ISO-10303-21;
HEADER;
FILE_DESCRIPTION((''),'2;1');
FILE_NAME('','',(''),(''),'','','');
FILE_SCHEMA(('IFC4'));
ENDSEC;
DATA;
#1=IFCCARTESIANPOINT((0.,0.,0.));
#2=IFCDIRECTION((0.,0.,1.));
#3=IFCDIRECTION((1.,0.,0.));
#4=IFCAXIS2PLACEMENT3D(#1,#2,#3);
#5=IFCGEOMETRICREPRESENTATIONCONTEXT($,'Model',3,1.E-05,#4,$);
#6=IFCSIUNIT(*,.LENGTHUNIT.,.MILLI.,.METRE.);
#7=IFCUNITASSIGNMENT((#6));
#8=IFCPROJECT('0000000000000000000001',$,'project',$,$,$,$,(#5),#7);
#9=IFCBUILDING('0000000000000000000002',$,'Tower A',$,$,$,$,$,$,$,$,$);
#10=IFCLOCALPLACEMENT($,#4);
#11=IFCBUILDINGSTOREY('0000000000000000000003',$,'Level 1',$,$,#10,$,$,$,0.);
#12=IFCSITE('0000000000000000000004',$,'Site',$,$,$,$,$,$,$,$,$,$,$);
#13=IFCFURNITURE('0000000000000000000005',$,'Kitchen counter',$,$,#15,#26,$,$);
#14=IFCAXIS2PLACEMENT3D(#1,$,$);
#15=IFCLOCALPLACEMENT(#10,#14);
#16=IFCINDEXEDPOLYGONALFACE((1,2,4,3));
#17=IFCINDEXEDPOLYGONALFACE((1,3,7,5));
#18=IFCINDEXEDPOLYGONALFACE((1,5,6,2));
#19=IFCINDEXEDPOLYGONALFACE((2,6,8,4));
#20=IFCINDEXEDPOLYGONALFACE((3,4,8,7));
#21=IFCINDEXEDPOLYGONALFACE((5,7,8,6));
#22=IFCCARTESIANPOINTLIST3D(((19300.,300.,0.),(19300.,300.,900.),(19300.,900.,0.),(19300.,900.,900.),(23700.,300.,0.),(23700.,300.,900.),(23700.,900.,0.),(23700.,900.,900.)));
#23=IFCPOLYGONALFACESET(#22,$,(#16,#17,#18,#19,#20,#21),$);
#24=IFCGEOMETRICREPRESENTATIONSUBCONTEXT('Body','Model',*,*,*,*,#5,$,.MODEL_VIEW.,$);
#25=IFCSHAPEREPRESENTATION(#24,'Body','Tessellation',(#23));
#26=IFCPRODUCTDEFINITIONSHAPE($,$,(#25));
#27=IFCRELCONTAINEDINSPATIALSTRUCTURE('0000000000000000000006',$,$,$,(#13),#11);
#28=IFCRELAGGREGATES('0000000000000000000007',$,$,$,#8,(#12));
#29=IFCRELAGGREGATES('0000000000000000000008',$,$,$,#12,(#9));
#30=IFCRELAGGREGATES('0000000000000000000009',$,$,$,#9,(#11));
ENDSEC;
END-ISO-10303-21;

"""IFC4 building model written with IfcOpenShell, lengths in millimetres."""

from ifc_helpers import new_model, si_unit, frame, origin_with_axes, place, context, subcontext, project, spatial, indexed_curve, outline, extrude, element, save


model = new_model("IFC4")

# Units and contexts
model_context = context("Model", 3, precision=1e-05, world=origin_with_axes())
body_context = subcontext(model_context, "Body", "Model", "MODEL_VIEW")
ifc_project = project(units=[si_unit("LENGTHUNIT", "METRE", prefix="MILLI")], contexts=[model_context])

# Site, building, storey
site = spatial("IfcSite", under=ifc_project, Name="Site")
building = spatial("IfcBuilding", under=site, Name="Tower A")
storey_placement = place(None, origin_with_axes())
storey = spatial("IfcBuildingStorey", under=building, at=storey_placement, Name="Level 1", Elevation=0.0)

# Furniture
furniture_1_placement = place(storey_placement, frame((19300.0, 300.0, 0.0), z_axis=(0.0, 0.0, 1.0), x_axis=(1.0, 0.0, 0.0)))
element("IfcFurniture", 1, at=furniture_1_placement, inside=storey, Name="Kitchen counter", context=body_context, shape_type="SweptSolid", body=[
    extrude(outline(indexed_curve([(0.0, 0.0), (4400.0, 0.0), (4400.0, 600.0), (0.0, 600.0)])), None, (0.0, 0.0, 1.0), 900.0),
])

save(model, "model.ifc")
